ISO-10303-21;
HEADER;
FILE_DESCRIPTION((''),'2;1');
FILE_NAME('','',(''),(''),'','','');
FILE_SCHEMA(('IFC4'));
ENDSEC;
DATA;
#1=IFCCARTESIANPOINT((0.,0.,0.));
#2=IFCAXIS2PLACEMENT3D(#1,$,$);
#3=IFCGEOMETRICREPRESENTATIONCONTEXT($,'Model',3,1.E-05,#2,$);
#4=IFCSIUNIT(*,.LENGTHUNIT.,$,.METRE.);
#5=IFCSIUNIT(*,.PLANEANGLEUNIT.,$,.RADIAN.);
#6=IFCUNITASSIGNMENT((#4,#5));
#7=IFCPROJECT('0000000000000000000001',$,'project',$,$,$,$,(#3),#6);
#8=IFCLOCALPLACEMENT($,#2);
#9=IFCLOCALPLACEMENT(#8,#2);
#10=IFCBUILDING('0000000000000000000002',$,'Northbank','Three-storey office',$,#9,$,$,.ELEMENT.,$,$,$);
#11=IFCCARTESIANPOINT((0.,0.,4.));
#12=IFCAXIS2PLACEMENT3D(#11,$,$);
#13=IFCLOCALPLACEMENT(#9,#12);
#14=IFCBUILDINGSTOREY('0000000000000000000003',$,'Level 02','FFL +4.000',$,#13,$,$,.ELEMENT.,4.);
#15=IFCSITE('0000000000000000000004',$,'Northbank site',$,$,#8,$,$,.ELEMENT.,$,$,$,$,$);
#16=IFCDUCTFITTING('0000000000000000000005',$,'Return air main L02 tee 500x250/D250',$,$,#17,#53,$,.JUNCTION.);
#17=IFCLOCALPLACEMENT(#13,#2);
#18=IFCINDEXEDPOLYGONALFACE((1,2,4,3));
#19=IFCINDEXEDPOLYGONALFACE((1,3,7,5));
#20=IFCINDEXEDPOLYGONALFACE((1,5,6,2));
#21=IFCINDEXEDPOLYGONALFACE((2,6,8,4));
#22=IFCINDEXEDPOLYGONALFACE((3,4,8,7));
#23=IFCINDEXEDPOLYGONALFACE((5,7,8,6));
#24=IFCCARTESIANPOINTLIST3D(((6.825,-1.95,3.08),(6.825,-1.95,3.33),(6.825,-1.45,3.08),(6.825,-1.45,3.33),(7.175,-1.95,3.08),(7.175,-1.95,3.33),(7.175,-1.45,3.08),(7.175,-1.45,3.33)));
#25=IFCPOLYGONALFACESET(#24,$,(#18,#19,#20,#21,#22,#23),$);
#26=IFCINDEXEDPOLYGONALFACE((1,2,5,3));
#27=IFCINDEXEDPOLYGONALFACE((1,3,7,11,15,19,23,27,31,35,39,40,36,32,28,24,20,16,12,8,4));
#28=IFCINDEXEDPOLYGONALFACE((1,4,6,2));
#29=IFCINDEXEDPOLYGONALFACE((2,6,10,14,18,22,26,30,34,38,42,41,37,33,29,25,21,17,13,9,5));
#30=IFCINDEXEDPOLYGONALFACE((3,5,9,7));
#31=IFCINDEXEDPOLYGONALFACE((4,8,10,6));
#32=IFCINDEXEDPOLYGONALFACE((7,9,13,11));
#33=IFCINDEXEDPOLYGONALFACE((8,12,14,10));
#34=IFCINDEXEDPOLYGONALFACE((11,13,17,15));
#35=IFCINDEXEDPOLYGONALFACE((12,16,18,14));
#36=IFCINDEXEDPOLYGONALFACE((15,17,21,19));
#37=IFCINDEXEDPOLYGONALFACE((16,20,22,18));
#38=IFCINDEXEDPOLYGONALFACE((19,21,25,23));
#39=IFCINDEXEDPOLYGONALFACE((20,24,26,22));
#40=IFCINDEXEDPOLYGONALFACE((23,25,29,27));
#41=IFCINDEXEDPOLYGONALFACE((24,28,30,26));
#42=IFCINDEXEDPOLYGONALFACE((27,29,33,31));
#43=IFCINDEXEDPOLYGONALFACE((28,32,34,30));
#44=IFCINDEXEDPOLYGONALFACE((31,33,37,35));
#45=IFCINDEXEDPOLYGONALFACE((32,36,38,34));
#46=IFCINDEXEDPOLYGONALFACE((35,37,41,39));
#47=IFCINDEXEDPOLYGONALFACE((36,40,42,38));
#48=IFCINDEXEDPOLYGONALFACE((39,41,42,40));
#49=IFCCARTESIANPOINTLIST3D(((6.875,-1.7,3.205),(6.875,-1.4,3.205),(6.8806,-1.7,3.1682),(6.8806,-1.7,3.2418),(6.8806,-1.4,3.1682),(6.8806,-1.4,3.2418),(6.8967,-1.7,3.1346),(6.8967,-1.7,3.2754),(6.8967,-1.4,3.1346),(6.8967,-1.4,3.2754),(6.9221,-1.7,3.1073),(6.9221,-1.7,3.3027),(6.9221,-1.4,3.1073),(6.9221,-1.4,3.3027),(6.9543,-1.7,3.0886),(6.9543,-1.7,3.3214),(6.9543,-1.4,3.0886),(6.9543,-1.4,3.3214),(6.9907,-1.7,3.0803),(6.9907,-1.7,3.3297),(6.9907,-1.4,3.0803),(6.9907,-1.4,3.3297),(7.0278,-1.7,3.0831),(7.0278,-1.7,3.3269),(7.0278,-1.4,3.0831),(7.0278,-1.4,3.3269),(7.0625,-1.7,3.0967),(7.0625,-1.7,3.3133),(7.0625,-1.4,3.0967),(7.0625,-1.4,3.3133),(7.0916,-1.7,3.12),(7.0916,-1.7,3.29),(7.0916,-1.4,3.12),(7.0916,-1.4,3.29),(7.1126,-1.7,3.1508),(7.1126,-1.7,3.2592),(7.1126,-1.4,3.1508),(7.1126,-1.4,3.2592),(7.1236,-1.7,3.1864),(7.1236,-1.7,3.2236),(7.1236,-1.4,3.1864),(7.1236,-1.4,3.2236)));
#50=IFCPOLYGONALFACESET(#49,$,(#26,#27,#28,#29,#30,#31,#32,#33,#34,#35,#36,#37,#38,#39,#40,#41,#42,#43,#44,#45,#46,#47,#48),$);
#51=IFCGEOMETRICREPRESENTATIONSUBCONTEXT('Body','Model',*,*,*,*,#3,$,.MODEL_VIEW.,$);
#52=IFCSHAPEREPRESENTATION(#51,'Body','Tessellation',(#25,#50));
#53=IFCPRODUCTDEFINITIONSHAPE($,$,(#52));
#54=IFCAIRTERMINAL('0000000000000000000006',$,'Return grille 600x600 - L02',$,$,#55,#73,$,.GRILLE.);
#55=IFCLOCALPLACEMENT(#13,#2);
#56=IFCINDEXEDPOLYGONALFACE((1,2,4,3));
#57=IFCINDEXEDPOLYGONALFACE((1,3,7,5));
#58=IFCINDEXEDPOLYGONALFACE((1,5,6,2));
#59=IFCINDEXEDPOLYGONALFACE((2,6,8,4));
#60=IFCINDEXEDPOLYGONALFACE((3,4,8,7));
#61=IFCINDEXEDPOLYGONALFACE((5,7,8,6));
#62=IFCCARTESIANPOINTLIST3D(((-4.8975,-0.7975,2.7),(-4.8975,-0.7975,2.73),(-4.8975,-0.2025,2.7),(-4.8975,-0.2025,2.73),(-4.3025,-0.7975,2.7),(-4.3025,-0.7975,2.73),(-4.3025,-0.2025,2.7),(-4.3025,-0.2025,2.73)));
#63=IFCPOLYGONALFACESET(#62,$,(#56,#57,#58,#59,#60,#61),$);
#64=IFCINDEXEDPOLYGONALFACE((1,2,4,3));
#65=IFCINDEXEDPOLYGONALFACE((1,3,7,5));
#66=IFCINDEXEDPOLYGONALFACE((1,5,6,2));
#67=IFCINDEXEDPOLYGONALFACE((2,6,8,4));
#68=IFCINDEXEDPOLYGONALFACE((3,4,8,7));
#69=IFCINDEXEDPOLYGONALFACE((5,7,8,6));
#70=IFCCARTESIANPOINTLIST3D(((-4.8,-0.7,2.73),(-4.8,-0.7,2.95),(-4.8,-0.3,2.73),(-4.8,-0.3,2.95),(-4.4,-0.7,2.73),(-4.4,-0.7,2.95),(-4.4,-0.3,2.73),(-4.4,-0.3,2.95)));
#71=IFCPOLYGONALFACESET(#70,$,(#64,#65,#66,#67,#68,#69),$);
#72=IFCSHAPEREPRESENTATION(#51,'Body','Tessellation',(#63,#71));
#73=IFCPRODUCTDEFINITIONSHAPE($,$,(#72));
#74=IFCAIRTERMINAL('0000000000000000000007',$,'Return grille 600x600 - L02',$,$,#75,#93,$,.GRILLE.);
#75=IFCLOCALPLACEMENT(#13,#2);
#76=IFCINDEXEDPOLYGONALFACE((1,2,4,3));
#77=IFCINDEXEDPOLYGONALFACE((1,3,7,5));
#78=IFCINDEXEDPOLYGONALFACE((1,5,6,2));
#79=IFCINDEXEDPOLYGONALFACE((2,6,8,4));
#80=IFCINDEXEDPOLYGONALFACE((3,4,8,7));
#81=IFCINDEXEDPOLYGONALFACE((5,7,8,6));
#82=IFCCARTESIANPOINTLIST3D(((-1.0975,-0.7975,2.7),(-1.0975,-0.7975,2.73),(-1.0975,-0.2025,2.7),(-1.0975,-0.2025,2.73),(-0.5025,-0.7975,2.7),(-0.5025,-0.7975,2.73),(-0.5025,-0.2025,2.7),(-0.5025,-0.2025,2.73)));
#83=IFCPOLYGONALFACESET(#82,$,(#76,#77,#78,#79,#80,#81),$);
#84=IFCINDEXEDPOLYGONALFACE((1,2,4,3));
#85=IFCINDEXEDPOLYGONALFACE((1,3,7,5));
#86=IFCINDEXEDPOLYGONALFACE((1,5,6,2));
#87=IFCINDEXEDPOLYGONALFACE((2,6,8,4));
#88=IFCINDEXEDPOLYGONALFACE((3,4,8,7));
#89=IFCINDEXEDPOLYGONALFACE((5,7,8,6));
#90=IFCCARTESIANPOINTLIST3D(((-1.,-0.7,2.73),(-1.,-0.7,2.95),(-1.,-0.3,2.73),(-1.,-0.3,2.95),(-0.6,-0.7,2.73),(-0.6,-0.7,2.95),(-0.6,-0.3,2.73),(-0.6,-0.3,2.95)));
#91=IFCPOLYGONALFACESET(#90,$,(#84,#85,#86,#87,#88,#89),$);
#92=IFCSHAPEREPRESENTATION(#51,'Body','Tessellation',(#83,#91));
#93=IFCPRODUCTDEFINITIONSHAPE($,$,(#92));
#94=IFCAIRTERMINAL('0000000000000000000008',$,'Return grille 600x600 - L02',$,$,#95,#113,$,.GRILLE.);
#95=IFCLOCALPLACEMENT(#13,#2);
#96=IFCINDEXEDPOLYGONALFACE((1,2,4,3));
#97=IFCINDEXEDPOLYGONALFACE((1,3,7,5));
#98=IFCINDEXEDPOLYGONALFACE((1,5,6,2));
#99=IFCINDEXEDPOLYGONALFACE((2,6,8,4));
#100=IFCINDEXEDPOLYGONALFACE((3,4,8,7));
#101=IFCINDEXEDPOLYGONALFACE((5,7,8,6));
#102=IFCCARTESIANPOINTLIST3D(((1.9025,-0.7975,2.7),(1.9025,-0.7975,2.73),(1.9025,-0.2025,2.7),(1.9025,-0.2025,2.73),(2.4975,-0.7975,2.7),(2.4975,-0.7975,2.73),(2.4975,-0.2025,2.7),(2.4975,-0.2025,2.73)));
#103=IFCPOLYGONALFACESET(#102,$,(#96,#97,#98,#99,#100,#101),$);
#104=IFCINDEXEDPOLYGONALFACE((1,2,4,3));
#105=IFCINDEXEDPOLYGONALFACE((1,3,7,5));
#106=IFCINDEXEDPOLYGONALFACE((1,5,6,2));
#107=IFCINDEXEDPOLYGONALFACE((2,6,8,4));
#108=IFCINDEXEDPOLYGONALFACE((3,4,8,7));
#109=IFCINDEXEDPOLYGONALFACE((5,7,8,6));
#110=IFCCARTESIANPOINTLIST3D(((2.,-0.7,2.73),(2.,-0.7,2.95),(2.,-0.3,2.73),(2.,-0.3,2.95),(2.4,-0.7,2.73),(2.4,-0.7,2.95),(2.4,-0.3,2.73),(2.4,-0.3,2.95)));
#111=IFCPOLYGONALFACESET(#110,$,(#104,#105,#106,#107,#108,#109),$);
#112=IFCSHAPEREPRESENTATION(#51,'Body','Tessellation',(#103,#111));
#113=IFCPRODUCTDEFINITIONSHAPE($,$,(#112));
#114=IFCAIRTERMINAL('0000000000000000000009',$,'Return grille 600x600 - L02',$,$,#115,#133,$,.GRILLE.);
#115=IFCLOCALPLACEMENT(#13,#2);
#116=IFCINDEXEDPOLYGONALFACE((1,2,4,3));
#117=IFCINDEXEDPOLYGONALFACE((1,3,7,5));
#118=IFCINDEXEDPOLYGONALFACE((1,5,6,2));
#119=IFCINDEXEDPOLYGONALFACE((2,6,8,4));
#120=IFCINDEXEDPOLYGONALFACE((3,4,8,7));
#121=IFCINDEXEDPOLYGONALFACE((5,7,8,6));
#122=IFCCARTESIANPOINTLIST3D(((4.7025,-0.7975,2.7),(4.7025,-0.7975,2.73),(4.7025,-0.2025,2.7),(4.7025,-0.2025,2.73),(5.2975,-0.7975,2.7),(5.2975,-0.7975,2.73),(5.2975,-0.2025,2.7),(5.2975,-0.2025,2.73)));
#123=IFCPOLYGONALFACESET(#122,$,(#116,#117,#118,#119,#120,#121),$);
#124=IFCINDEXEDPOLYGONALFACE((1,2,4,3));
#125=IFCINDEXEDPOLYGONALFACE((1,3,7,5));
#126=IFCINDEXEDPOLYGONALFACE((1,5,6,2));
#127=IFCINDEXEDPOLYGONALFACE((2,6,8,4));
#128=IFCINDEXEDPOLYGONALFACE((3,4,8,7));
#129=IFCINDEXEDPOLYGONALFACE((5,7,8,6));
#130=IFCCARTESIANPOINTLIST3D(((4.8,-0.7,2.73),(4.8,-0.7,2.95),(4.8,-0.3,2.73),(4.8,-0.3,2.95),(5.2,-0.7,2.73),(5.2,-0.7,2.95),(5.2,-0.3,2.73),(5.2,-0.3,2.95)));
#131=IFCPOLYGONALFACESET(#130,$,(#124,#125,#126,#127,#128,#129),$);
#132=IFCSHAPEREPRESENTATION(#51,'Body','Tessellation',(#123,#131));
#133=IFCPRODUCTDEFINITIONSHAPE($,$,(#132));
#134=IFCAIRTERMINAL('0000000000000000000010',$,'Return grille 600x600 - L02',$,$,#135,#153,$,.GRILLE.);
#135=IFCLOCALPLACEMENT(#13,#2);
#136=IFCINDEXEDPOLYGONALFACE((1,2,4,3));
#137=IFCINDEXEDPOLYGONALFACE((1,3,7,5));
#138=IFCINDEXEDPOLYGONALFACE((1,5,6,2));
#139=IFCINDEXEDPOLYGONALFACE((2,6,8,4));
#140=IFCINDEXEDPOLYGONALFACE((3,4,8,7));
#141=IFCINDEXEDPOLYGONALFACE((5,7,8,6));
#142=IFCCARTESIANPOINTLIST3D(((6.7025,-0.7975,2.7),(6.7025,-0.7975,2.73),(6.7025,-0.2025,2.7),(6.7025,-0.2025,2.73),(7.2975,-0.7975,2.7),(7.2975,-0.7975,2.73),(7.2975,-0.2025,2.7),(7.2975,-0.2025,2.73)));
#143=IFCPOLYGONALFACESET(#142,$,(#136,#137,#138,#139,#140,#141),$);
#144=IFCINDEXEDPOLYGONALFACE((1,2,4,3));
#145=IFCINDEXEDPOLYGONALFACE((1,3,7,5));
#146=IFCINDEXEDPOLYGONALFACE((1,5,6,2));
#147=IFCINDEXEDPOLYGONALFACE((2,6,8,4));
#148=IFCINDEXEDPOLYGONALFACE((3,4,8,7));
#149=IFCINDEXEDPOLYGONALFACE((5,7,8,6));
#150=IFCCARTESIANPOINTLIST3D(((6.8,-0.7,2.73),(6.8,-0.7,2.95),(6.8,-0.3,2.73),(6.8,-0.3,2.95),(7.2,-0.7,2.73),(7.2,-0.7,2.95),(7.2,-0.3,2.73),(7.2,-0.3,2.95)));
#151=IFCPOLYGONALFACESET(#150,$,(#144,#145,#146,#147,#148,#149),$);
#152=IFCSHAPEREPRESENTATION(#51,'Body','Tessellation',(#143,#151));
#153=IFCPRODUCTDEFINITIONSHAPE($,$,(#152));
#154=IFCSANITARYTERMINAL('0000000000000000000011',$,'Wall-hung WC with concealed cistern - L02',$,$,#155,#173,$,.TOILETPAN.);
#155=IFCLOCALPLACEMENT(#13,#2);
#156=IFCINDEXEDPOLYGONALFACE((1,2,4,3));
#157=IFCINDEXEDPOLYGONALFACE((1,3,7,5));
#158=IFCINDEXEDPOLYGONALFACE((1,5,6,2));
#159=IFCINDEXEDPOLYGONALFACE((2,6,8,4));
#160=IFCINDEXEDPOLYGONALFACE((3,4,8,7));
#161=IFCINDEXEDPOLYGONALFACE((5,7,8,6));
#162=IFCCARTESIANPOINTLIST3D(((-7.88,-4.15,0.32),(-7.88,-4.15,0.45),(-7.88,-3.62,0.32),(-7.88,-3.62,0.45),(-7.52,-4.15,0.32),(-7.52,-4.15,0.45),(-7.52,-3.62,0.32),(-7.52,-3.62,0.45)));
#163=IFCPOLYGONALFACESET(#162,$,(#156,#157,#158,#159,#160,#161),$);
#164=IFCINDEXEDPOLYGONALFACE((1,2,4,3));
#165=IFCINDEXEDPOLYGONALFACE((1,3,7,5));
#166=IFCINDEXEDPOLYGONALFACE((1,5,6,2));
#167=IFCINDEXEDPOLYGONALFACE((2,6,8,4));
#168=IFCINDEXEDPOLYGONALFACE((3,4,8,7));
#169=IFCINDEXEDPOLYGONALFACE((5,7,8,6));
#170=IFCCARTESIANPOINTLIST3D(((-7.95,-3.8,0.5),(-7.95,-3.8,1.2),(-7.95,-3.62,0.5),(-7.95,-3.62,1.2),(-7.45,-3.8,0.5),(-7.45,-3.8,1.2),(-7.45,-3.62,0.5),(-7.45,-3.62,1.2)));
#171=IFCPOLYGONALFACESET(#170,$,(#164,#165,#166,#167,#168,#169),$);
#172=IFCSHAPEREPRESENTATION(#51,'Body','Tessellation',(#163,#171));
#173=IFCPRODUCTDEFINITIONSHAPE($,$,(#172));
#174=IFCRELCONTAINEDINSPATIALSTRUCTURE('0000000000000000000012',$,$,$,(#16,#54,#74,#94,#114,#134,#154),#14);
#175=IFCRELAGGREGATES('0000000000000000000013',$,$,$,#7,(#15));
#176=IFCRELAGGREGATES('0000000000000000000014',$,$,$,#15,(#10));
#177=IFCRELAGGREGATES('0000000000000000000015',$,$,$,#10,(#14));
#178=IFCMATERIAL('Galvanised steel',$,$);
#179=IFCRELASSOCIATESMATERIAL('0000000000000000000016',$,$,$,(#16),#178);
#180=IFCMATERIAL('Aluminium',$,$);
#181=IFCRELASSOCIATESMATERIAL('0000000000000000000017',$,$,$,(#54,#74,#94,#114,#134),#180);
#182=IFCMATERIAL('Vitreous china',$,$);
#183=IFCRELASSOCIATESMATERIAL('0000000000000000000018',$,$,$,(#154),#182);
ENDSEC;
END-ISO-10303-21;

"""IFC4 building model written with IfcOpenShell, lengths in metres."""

from ifc_helpers import new_model, si_unit, frame, origin, place, context, subcontext, project, spatial, rectangle, circle, extrude, material, element, save


model = new_model("IFC4")

# Units and contexts
model_context = context("Model", 3, precision=1e-05, world=origin())
body_context = subcontext(model_context, "Body", "Model", "MODEL_VIEW")
ifc_project = project(units=[si_unit("LENGTHUNIT", "METRE"), si_unit("PLANEANGLEUNIT", "RADIAN")], contexts=[model_context])

# Site, building, storey
site_placement = place(None, origin())
site = spatial("IfcSite", under=ifc_project, at=site_placement, Name="Northbank site", CompositionType="ELEMENT")
building_placement = place(site_placement, origin())
building = spatial("IfcBuilding", under=site, at=building_placement, Name="Northbank", Description="Three-storey office", CompositionType="ELEMENT")
storey_placement = place(building_placement, frame((0.0, 0.0, 4.0)))
storey = spatial("IfcBuildingStorey", under=building, at=storey_placement, Name="Level 02", Description="FFL +4.000", CompositionType="ELEMENT", Elevation=4.0)

# Shared definitions
ifc_material_1 = material(Name="Galvanised steel")

# Duct fitting
duct_fitting_1_placement = place(storey_placement, frame((0.0, 0.0, -4.0)))
element("IfcDuctFitting", 1, at=duct_fitting_1_placement, inside=storey, material=ifc_material_1, Name="Return air main L02 tee 500x250/D250", PredefinedType="JUNCTION", context=body_context, shape_type="SweptSolid", body=[
    extrude(rectangle(XDim=0.5, YDim=0.25), frame((6.825, -1.7, 7.205), z_axis=(1.0, 0.0, 0.0), x_axis=(0.0, 1.0, 0.0)), (0.0, 0.0, 1.0), 0.35),
    extrude(circle(Radius=0.125), frame((7.0, -1.7, 7.205), z_axis=(0.0, 1.0, 0.0), x_axis=(-1.0, 0.0, 0.0)), (0.0, 0.0, 1.0), 0.3),
])

# Air terminal
ifc_material_2 = material(Name="Aluminium")
air_terminal_1_placement = place(storey_placement, frame((0.0, 0.0, -4.0)))
element("IfcAirTerminal", 2, at=air_terminal_1_placement, inside=storey, material=ifc_material_2, Name="Return grille 600x600 - L02", PredefinedType="GRILLE", context=body_context, shape_type="SweptSolid", body=[
    extrude(rectangle(XDim=0.595, YDim=0.595), frame((-4.6, -0.5, 6.7)), (0.0, 0.0, 1.0), 0.03),
    extrude(rectangle(XDim=0.4, YDim=0.4), frame((-4.6, -0.5, 6.73)), (0.0, 0.0, 1.0), 0.22),
])

# Air terminal
air_terminal_2_placement = place(storey_placement, frame((0.0, 0.0, -4.0)))
element("IfcAirTerminal", 3, at=air_terminal_2_placement, inside=storey, material=ifc_material_2, Name="Return grille 600x600 - L02", PredefinedType="GRILLE", context=body_context, shape_type="SweptSolid", body=[
    extrude(rectangle(XDim=0.595, YDim=0.595), frame((-0.8, -0.5, 6.7)), (0.0, 0.0, 1.0), 0.03),
    extrude(rectangle(XDim=0.4, YDim=0.4), frame((-0.8, -0.5, 6.73)), (0.0, 0.0, 1.0), 0.22),
])

# Air terminal
air_terminal_3_placement = place(storey_placement, frame((0.0, 0.0, -4.0)))
element("IfcAirTerminal", 4, at=air_terminal_3_placement, inside=storey, material=ifc_material_2, Name="Return grille 600x600 - L02", PredefinedType="GRILLE", context=body_context, shape_type="SweptSolid", body=[
    extrude(rectangle(XDim=0.595, YDim=0.595), frame((2.2, -0.5, 6.7)), (0.0, 0.0, 1.0), 0.03),
    extrude(rectangle(XDim=0.4, YDim=0.4), frame((2.2, -0.5, 6.73)), (0.0, 0.0, 1.0), 0.22),
])

# Air terminal
air_terminal_4_placement = place(storey_placement, frame((0.0, 0.0, -4.0)))
element("IfcAirTerminal", 5, at=air_terminal_4_placement, inside=storey, material=ifc_material_2, Name="Return grille 600x600 - L02", PredefinedType="GRILLE", context=body_context, shape_type="SweptSolid", body=[
    extrude(rectangle(XDim=0.595, YDim=0.595), frame((5.0, -0.5, 6.7)), (0.0, 0.0, 1.0), 0.03),
    extrude(rectangle(XDim=0.4, YDim=0.4), frame((5.0, -0.5, 6.73)), (0.0, 0.0, 1.0), 0.22),
])

# Air terminal
air_terminal_5_placement = place(storey_placement, frame((0.0, 0.0, -4.0)))
element("IfcAirTerminal", 6, at=air_terminal_5_placement, inside=storey, material=ifc_material_2, Name="Return grille 600x600 - L02", PredefinedType="GRILLE", context=body_context, shape_type="SweptSolid", body=[
    extrude(rectangle(XDim=0.595, YDim=0.595), frame((7.0, -0.5, 6.7)), (0.0, 0.0, 1.0), 0.03),
    extrude(rectangle(XDim=0.4, YDim=0.4), frame((7.0, -0.5, 6.73)), (0.0, 0.0, 1.0), 0.22),
])

# Sanitary terminal
ifc_material_3 = material(Name="Vitreous china")
sanitary_terminal_1_placement = place(storey_placement, frame((0.0, 0.0, -4.0)))
element("IfcSanitaryTerminal", 7, at=sanitary_terminal_1_placement, inside=storey, material=ifc_material_3, Name="Wall-hung WC with concealed cistern - L02", PredefinedType="TOILETPAN", context=body_context, shape_type="SweptSolid", body=[
    extrude(rectangle(XDim=0.36, YDim=0.53), frame((-7.7, -3.885, 4.32)), (0.0, 0.0, 1.0), 0.13),
    extrude(rectangle(XDim=0.5, YDim=0.18), frame((-7.7, -3.71, 4.5)), (0.0, 0.0, 1.0), 0.7),
])

save(model, "model.ifc")
